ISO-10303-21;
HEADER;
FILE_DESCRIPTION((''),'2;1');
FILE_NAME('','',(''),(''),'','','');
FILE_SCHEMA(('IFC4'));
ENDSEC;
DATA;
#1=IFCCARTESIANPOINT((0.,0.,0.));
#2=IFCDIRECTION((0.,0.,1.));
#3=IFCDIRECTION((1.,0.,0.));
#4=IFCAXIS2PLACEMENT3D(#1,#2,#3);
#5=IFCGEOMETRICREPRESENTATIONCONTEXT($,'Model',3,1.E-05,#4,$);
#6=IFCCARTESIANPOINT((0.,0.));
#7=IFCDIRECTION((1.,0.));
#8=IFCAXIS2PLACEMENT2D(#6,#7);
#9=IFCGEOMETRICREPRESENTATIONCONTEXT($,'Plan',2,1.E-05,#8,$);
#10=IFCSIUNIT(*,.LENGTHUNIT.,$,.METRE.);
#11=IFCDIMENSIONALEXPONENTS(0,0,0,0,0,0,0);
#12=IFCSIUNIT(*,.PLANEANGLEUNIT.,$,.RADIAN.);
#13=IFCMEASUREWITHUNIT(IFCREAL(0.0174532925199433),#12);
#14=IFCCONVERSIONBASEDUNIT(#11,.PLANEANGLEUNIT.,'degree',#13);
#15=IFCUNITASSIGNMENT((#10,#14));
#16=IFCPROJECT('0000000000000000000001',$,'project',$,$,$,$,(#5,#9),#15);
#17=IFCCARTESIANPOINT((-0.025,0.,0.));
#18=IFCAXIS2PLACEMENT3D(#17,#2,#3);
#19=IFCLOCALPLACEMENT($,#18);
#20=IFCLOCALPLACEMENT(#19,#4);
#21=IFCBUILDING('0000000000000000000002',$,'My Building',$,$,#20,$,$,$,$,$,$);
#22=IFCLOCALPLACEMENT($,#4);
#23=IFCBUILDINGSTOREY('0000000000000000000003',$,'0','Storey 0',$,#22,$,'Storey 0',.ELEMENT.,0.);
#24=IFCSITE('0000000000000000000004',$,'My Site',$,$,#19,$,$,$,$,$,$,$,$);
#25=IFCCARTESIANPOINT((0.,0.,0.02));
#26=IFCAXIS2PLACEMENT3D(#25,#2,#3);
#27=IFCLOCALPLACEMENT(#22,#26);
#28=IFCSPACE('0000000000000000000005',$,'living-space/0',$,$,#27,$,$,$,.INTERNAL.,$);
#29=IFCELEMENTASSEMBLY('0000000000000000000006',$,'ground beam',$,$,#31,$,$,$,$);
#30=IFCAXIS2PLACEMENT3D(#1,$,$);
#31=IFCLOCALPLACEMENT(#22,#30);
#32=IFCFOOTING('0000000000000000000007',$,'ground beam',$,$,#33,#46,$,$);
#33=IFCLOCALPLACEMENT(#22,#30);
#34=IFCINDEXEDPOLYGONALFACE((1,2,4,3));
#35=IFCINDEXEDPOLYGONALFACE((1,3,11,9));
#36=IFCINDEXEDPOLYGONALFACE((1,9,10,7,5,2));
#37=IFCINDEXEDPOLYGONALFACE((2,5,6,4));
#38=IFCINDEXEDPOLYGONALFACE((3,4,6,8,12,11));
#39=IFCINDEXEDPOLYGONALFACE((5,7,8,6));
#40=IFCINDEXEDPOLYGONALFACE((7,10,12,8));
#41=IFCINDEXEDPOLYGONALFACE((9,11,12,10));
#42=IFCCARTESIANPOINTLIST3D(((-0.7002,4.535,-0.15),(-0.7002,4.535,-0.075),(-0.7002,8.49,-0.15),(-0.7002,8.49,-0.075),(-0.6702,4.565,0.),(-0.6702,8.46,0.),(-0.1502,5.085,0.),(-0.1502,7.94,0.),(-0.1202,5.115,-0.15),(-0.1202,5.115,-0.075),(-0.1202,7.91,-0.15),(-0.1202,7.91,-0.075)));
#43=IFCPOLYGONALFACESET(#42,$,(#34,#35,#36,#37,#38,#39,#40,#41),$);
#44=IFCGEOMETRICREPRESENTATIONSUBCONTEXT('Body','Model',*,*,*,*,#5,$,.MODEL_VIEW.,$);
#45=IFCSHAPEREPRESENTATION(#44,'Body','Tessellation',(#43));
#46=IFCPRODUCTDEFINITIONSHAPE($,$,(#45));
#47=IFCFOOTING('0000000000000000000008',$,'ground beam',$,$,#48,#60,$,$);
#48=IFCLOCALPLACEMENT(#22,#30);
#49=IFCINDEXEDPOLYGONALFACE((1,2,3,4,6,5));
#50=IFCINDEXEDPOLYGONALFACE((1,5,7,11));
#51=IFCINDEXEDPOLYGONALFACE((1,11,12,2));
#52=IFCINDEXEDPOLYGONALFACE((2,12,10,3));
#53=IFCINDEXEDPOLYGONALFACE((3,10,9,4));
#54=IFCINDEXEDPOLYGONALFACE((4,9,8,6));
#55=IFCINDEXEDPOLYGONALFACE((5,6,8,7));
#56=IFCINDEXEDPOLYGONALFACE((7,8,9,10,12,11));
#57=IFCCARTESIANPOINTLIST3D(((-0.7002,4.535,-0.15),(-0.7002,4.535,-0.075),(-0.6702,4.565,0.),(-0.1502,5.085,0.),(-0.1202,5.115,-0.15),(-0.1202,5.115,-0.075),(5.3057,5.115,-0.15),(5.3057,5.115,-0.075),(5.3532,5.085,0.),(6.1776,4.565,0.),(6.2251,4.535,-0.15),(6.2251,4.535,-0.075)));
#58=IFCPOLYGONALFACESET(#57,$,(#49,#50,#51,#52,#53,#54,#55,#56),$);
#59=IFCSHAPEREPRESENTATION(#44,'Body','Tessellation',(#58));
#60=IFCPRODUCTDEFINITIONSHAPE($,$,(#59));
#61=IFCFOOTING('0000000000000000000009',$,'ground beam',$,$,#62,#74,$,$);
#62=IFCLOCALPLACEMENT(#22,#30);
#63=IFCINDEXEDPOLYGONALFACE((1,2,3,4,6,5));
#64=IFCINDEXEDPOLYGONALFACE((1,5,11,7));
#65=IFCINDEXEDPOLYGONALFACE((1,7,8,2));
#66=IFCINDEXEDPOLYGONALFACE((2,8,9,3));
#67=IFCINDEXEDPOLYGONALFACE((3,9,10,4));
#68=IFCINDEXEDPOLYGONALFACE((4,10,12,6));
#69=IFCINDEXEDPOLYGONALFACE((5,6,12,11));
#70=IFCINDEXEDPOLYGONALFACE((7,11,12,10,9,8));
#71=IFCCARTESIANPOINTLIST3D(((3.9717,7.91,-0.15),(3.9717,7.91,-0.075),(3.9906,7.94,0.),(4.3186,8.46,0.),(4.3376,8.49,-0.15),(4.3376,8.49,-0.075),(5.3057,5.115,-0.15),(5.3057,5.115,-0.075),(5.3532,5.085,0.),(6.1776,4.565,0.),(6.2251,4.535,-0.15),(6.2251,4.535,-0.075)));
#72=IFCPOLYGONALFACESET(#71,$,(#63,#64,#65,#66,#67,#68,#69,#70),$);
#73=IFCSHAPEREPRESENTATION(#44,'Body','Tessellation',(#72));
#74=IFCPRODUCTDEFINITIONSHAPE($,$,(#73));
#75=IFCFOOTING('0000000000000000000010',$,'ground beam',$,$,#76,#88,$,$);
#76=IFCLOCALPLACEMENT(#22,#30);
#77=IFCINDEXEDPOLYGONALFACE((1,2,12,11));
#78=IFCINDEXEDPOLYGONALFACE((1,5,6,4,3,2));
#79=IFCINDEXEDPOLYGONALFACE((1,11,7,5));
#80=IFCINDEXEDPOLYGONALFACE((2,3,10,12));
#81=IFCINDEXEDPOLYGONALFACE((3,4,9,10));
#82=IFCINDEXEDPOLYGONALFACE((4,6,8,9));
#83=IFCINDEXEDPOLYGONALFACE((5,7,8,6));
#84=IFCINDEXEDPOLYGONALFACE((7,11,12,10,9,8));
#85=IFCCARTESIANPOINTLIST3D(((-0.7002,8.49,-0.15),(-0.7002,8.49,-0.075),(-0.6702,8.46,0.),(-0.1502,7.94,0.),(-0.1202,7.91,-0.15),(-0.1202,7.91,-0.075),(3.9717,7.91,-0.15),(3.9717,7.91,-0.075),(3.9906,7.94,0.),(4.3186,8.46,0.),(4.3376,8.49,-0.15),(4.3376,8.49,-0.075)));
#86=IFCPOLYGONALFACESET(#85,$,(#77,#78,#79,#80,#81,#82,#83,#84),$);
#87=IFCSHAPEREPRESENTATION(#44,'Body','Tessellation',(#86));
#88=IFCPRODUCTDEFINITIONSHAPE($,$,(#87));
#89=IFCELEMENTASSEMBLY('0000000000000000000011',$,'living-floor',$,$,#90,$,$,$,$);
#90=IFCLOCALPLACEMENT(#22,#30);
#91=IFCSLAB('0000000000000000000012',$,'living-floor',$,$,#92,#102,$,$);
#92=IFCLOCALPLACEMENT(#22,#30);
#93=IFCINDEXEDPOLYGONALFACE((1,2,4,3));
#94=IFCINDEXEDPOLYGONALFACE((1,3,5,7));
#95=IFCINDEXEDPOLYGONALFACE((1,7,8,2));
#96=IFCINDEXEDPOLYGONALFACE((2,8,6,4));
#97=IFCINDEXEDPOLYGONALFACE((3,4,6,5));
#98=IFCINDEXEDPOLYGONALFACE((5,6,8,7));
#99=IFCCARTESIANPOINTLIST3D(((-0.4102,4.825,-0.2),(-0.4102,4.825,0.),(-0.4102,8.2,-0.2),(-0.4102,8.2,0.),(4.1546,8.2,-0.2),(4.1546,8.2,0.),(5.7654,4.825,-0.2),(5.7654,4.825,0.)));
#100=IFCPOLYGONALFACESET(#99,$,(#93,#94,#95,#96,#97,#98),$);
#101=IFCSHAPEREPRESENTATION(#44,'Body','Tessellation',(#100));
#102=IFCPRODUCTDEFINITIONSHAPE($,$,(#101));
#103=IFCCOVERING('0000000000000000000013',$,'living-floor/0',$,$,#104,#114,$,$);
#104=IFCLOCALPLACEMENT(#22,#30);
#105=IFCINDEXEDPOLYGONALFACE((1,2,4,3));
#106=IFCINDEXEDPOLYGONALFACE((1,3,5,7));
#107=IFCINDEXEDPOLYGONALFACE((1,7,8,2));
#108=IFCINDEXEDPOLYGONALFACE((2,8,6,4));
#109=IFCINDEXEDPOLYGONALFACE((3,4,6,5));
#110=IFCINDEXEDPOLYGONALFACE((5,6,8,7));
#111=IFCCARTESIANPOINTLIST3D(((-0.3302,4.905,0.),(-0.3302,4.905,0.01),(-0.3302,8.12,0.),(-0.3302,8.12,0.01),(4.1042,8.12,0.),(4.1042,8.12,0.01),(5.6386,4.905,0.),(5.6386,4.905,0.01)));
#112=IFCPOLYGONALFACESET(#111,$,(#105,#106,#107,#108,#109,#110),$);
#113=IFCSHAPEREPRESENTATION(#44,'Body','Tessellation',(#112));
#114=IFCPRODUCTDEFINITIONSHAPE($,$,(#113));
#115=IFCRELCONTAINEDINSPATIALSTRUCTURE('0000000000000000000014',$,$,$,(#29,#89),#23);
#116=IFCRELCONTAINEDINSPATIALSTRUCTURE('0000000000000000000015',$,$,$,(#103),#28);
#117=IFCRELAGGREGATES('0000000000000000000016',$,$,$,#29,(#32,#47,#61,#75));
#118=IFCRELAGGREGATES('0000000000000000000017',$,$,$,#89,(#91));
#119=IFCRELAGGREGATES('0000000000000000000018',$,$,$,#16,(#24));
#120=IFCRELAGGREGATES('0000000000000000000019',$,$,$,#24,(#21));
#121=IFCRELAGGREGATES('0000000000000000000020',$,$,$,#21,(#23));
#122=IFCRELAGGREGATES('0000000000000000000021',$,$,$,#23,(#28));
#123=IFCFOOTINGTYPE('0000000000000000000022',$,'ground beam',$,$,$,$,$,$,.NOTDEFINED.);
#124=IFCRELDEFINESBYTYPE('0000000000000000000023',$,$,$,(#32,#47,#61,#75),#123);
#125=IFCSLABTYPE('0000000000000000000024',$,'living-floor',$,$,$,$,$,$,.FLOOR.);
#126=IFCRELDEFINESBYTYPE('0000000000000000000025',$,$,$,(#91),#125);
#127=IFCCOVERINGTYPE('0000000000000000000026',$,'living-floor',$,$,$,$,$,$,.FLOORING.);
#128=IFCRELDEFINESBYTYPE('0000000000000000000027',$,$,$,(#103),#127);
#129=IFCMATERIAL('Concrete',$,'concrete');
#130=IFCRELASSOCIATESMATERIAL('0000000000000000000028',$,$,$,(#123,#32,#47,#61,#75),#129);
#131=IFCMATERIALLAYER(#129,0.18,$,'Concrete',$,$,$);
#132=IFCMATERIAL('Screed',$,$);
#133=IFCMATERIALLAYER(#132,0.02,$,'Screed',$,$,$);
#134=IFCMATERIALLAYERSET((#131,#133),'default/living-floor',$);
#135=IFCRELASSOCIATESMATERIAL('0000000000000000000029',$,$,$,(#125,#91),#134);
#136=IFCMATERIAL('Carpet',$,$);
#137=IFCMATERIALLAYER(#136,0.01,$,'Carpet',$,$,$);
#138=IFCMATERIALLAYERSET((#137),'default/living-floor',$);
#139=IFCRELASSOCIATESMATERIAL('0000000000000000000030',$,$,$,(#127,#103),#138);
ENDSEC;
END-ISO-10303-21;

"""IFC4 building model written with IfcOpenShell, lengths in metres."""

from ifc_helpers import new_model, entity, si_unit, converted_unit, frame, origin, origin_with_axes, origin_2d_with_axis, place, context, subcontext, project, spatial, polyline, outline, extrude, clip, halfspace, material, layer, layer_set, layer_usage, material_profile, profile_set, profile_usage, type_object, element, aggregate, save


model = new_model("IFC4")

# Units and contexts
model_context = context("Model", 3, precision=1e-05, world=origin_with_axes())
plan_context = context("Plan", 2, precision=1e-05, world=origin_2d_with_axis())
body_context = subcontext(model_context, "Body", "Model", "MODEL_VIEW")
ifc_project = project(units=[si_unit("LENGTHUNIT", "METRE"), converted_unit("PLANEANGLEUNIT", "degree", entity("IfcReal", 0.0174532925199433), si_unit("PLANEANGLEUNIT", "RADIAN"), dimensions=[0, 0, 0, 0, 0, 0, 0])], contexts=[model_context, plan_context])

# Site, building, storey
site_placement = place(None, frame((-0.025, 0.0, 0.0), z_axis=(0.0, 0.0, 1.0), x_axis=(1.0, 0.0, 0.0)))
site = spatial("IfcSite", under=ifc_project, at=site_placement, Name="My Site")
building_placement = place(site_placement, origin_with_axes())
building = spatial("IfcBuilding", under=site, at=building_placement, Name="My Building")
storey_placement = place(None, origin_with_axes())
storey = spatial("IfcBuildingStorey", under=building, at=storey_placement, Name="0", Description="Storey 0", LongName="Storey 0", CompositionType="ELEMENT", Elevation=0.0)

# Element assembly, footings
assembly_1_placement = place(storey_placement, origin_with_axes())
assembly_1 = element("IfcElementAssembly", 1, at=assembly_1_placement, inside=storey, Name="ground beam")
ifc_material_1 = material(Name="Concrete", Category="concrete")
ifc_material_profile = material_profile(ifc_material_1, outline(polyline([(-0.26, 0.0), (-0.29, -0.075), (-0.29, -0.15), (0.29, -0.15), (0.29, -0.075), (0.26, 0.0), (-0.26, 0.0)])))
ifc_profile_set = profile_set([ifc_material_profile])
ifc_profile_usage_1 = profile_usage(ifc_profile_set)
footing_type = type_object("IfcFootingType", Name="ground beam", PredefinedType="NOTDEFINED", material=ifc_profile_set)
footing_1_placement = place(assembly_1_placement, frame((-0.4102, 3.825, 0.0), z_axis=(0.0, 1.0, 0.0), x_axis=(-1.0, 0.0, 0.0)))
footing_1 = element("IfcFooting", 2, at=footing_1_placement, type_object=footing_type, material=ifc_profile_usage_1, Name="ground beam", context=body_context, shape_type="Clipping", body=[
    clip(clip(extrude(outline(polyline([(-0.26, 0.0), (-0.29, -0.075), (-0.29, -0.15), (0.29, -0.15), (0.29, -0.075), (0.26, 0.0), (-0.26, 0.0)])), origin_with_axes(), (0.0, 0.0, 1.0), 5.375), halfspace(frame((0.0, 0.0, 1.0), z_axis=(-0.707107, 0.0, -0.707107), x_axis=(0.0, 1.0, 0.0)), False)), halfspace(frame((0.0, 0.0, 4.375), z_axis=(-0.707107, 0.0, 0.707107), x_axis=(0.0, 1.0, 0.0)), False)),
])
ifc_profile_usage_2 = profile_usage(ifc_profile_set)
footing_2_placement = place(assembly_1_placement, frame((6.7654, 4.825, 0.0), z_axis=(-1.0, 0.0, 0.0), x_axis=(0.0, -1.0, 0.0)))
footing_2 = element("IfcFooting", 3, at=footing_2_placement, type_object=footing_type, material=ifc_profile_usage_2, Name="ground beam", context=body_context, shape_type="Clipping", body=[
    clip(clip(extrude(outline(polyline([(-0.26, 0.0), (-0.29, -0.075), (-0.29, -0.15), (0.29, -0.15), (0.29, -0.075), (0.26, 0.0), (-0.26, 0.0)])), origin_with_axes(), (0.0, 0.0, 1.0), 8.1756), halfspace(frame((0.0, 0.0, 1.0), z_axis=(-0.845791, 0.0, -0.533515), x_axis=(0.0, 1.0, 0.0)), False)), halfspace(frame((0.0, 0.0, 7.1756), z_axis=(-0.707107, 0.0, 0.707107), x_axis=(0.0, 1.0, 0.0)), False)),
])
ifc_profile_usage_3 = profile_usage(ifc_profile_set)
footing_3_placement = place(assembly_1_placement, frame((3.7239, 9.1025, 0.0), z_axis=(0.430724, -0.902484, 0.0), x_axis=(0.902484, 0.430724, 0.0)))
footing_3 = element("IfcFooting", 4, at=footing_3_placement, type_object=footing_type, material=ifc_profile_usage_3, Name="ground beam", context=body_context, shape_type="Clipping", body=[
    clip(clip(extrude(outline(polyline([(-0.26, 0.0), (-0.29, -0.075), (-0.29, -0.15), (0.29, -0.15), (0.29, -0.075), (0.26, 0.0), (-0.26, 0.0)])), origin_with_axes(), (0.0, 0.0, 1.0), 5.7397), halfspace(frame((0.0, 0.0, 1.0), z_axis=(-0.533515, 0.0, -0.845791), x_axis=(0.0, 1.0, 0.0)), False)), halfspace(frame((0.0, 0.0, 4.7397), z_axis=(-0.845791, 0.0, 0.533515), x_axis=(0.0, 1.0, 0.0)), False)),
])
ifc_profile_usage_4 = profile_usage(ifc_profile_set)
footing_4_placement = place(assembly_1_placement, frame((-1.4102, 8.2, 0.0), z_axis=(1.0, 0.0, 0.0), x_axis=(0.0, 1.0, 0.0)))
footing_4 = element("IfcFooting", 5, at=footing_4_placement, type_object=footing_type, material=ifc_profile_usage_4, Name="ground beam", context=body_context, shape_type="Clipping", body=[
    clip(clip(extrude(outline(polyline([(-0.26, 0.0), (-0.29, -0.075), (-0.29, -0.15), (0.29, -0.15), (0.29, -0.075), (0.26, 0.0), (-0.26, 0.0)])), origin_with_axes(), (0.0, 0.0, 1.0), 6.5648), halfspace(frame((0.0, 0.0, 1.0), z_axis=(-0.707107, 0.0, -0.707107), x_axis=(0.0, 1.0, 0.0)), False)), halfspace(frame((0.0, 0.0, 5.5648), z_axis=(-0.533515, 0.0, 0.845791), x_axis=(0.0, 1.0, 0.0)), False)),
])
aggregate(assembly_1, [footing_1, footing_2, footing_3, footing_4])

# Element assembly, slab
assembly_2_placement = place(storey_placement, origin_with_axes())
assembly_2 = element("IfcElementAssembly", 6, at=assembly_2_placement, inside=storey, Name="living-floor")
ifc_layer_1 = layer(ifc_material_1, 0.18, Name="Concrete")
ifc_material_2 = material(Name="Screed")
ifc_layer_2 = layer(ifc_material_2, 0.02, Name="Screed")
ifc_layer_set_1 = layer_set([ifc_layer_1, ifc_layer_2], Name="default/living-floor")
ifc_layer_usage_1 = layer_usage(ifc_layer_set_1, "AXIS3", "POSITIVE", 0.0)
slab_type = type_object("IfcSlabType", Name="living-floor", PredefinedType="FLOOR", material=ifc_layer_set_1)
slab_placement = place(assembly_2_placement, frame((4.1546, 8.2, -0.2), z_axis=(0.0, 0.0, -1.0), x_axis=(0.0, 1.0, 0.0)))
slab = element("IfcSlab", 7, at=slab_placement, type_object=slab_type, material=ifc_layer_usage_1, Name="living-floor", context=body_context, shape_type="SweptSolid", body=[
    extrude(outline(polyline([(0.0, 0.0), (-3.375, 1.6108), (-3.375, -4.5648), (0.0, -4.5648), (0.0, 0.0)])), origin(), (0.0, 0.0, -1.0), 0.2),
])
aggregate(assembly_2, [slab])

# Shared definitions
space_placement = place(storey_placement, frame((0.0, 0.0, 0.02), z_axis=(0.0, 0.0, 1.0), x_axis=(1.0, 0.0, 0.0)))
space = spatial("IfcSpace", under=storey, at=space_placement, Name="living-space/0", PredefinedType="INTERNAL")

# Covering
ifc_material_3 = material(Name="Carpet")
ifc_layer_3 = layer(ifc_material_3, 0.01, Name="Carpet")
ifc_layer_set_2 = layer_set([ifc_layer_3], Name="default/living-floor")
ifc_layer_usage_2 = layer_usage(ifc_layer_set_2, "AXIS2", "POSITIVE", 0.0)
covering_type = type_object("IfcCoveringType", Name="living-floor", PredefinedType="FLOORING", material=ifc_layer_set_2)
covering_placement = place(space_placement, frame((0.0, 0.0, -0.02), z_axis=(0.0, 0.0, 1.0), x_axis=(1.0, 0.0, 0.0)))
element("IfcCovering", 8, at=covering_placement, inside=space, type_object=covering_type, material=ifc_layer_usage_2, Name="living-floor/0", context=body_context, shape_type="SweptSolid", body=[
    extrude(outline(polyline([(4.1042, 8.12), (-0.3302, 8.12), (-0.3302, 4.905), (5.6386, 4.905), (4.1042, 8.12)])), origin_with_axes(), (0.0, 0.0, 1.0), 0.01),
])

save(model, "model.ifc")
